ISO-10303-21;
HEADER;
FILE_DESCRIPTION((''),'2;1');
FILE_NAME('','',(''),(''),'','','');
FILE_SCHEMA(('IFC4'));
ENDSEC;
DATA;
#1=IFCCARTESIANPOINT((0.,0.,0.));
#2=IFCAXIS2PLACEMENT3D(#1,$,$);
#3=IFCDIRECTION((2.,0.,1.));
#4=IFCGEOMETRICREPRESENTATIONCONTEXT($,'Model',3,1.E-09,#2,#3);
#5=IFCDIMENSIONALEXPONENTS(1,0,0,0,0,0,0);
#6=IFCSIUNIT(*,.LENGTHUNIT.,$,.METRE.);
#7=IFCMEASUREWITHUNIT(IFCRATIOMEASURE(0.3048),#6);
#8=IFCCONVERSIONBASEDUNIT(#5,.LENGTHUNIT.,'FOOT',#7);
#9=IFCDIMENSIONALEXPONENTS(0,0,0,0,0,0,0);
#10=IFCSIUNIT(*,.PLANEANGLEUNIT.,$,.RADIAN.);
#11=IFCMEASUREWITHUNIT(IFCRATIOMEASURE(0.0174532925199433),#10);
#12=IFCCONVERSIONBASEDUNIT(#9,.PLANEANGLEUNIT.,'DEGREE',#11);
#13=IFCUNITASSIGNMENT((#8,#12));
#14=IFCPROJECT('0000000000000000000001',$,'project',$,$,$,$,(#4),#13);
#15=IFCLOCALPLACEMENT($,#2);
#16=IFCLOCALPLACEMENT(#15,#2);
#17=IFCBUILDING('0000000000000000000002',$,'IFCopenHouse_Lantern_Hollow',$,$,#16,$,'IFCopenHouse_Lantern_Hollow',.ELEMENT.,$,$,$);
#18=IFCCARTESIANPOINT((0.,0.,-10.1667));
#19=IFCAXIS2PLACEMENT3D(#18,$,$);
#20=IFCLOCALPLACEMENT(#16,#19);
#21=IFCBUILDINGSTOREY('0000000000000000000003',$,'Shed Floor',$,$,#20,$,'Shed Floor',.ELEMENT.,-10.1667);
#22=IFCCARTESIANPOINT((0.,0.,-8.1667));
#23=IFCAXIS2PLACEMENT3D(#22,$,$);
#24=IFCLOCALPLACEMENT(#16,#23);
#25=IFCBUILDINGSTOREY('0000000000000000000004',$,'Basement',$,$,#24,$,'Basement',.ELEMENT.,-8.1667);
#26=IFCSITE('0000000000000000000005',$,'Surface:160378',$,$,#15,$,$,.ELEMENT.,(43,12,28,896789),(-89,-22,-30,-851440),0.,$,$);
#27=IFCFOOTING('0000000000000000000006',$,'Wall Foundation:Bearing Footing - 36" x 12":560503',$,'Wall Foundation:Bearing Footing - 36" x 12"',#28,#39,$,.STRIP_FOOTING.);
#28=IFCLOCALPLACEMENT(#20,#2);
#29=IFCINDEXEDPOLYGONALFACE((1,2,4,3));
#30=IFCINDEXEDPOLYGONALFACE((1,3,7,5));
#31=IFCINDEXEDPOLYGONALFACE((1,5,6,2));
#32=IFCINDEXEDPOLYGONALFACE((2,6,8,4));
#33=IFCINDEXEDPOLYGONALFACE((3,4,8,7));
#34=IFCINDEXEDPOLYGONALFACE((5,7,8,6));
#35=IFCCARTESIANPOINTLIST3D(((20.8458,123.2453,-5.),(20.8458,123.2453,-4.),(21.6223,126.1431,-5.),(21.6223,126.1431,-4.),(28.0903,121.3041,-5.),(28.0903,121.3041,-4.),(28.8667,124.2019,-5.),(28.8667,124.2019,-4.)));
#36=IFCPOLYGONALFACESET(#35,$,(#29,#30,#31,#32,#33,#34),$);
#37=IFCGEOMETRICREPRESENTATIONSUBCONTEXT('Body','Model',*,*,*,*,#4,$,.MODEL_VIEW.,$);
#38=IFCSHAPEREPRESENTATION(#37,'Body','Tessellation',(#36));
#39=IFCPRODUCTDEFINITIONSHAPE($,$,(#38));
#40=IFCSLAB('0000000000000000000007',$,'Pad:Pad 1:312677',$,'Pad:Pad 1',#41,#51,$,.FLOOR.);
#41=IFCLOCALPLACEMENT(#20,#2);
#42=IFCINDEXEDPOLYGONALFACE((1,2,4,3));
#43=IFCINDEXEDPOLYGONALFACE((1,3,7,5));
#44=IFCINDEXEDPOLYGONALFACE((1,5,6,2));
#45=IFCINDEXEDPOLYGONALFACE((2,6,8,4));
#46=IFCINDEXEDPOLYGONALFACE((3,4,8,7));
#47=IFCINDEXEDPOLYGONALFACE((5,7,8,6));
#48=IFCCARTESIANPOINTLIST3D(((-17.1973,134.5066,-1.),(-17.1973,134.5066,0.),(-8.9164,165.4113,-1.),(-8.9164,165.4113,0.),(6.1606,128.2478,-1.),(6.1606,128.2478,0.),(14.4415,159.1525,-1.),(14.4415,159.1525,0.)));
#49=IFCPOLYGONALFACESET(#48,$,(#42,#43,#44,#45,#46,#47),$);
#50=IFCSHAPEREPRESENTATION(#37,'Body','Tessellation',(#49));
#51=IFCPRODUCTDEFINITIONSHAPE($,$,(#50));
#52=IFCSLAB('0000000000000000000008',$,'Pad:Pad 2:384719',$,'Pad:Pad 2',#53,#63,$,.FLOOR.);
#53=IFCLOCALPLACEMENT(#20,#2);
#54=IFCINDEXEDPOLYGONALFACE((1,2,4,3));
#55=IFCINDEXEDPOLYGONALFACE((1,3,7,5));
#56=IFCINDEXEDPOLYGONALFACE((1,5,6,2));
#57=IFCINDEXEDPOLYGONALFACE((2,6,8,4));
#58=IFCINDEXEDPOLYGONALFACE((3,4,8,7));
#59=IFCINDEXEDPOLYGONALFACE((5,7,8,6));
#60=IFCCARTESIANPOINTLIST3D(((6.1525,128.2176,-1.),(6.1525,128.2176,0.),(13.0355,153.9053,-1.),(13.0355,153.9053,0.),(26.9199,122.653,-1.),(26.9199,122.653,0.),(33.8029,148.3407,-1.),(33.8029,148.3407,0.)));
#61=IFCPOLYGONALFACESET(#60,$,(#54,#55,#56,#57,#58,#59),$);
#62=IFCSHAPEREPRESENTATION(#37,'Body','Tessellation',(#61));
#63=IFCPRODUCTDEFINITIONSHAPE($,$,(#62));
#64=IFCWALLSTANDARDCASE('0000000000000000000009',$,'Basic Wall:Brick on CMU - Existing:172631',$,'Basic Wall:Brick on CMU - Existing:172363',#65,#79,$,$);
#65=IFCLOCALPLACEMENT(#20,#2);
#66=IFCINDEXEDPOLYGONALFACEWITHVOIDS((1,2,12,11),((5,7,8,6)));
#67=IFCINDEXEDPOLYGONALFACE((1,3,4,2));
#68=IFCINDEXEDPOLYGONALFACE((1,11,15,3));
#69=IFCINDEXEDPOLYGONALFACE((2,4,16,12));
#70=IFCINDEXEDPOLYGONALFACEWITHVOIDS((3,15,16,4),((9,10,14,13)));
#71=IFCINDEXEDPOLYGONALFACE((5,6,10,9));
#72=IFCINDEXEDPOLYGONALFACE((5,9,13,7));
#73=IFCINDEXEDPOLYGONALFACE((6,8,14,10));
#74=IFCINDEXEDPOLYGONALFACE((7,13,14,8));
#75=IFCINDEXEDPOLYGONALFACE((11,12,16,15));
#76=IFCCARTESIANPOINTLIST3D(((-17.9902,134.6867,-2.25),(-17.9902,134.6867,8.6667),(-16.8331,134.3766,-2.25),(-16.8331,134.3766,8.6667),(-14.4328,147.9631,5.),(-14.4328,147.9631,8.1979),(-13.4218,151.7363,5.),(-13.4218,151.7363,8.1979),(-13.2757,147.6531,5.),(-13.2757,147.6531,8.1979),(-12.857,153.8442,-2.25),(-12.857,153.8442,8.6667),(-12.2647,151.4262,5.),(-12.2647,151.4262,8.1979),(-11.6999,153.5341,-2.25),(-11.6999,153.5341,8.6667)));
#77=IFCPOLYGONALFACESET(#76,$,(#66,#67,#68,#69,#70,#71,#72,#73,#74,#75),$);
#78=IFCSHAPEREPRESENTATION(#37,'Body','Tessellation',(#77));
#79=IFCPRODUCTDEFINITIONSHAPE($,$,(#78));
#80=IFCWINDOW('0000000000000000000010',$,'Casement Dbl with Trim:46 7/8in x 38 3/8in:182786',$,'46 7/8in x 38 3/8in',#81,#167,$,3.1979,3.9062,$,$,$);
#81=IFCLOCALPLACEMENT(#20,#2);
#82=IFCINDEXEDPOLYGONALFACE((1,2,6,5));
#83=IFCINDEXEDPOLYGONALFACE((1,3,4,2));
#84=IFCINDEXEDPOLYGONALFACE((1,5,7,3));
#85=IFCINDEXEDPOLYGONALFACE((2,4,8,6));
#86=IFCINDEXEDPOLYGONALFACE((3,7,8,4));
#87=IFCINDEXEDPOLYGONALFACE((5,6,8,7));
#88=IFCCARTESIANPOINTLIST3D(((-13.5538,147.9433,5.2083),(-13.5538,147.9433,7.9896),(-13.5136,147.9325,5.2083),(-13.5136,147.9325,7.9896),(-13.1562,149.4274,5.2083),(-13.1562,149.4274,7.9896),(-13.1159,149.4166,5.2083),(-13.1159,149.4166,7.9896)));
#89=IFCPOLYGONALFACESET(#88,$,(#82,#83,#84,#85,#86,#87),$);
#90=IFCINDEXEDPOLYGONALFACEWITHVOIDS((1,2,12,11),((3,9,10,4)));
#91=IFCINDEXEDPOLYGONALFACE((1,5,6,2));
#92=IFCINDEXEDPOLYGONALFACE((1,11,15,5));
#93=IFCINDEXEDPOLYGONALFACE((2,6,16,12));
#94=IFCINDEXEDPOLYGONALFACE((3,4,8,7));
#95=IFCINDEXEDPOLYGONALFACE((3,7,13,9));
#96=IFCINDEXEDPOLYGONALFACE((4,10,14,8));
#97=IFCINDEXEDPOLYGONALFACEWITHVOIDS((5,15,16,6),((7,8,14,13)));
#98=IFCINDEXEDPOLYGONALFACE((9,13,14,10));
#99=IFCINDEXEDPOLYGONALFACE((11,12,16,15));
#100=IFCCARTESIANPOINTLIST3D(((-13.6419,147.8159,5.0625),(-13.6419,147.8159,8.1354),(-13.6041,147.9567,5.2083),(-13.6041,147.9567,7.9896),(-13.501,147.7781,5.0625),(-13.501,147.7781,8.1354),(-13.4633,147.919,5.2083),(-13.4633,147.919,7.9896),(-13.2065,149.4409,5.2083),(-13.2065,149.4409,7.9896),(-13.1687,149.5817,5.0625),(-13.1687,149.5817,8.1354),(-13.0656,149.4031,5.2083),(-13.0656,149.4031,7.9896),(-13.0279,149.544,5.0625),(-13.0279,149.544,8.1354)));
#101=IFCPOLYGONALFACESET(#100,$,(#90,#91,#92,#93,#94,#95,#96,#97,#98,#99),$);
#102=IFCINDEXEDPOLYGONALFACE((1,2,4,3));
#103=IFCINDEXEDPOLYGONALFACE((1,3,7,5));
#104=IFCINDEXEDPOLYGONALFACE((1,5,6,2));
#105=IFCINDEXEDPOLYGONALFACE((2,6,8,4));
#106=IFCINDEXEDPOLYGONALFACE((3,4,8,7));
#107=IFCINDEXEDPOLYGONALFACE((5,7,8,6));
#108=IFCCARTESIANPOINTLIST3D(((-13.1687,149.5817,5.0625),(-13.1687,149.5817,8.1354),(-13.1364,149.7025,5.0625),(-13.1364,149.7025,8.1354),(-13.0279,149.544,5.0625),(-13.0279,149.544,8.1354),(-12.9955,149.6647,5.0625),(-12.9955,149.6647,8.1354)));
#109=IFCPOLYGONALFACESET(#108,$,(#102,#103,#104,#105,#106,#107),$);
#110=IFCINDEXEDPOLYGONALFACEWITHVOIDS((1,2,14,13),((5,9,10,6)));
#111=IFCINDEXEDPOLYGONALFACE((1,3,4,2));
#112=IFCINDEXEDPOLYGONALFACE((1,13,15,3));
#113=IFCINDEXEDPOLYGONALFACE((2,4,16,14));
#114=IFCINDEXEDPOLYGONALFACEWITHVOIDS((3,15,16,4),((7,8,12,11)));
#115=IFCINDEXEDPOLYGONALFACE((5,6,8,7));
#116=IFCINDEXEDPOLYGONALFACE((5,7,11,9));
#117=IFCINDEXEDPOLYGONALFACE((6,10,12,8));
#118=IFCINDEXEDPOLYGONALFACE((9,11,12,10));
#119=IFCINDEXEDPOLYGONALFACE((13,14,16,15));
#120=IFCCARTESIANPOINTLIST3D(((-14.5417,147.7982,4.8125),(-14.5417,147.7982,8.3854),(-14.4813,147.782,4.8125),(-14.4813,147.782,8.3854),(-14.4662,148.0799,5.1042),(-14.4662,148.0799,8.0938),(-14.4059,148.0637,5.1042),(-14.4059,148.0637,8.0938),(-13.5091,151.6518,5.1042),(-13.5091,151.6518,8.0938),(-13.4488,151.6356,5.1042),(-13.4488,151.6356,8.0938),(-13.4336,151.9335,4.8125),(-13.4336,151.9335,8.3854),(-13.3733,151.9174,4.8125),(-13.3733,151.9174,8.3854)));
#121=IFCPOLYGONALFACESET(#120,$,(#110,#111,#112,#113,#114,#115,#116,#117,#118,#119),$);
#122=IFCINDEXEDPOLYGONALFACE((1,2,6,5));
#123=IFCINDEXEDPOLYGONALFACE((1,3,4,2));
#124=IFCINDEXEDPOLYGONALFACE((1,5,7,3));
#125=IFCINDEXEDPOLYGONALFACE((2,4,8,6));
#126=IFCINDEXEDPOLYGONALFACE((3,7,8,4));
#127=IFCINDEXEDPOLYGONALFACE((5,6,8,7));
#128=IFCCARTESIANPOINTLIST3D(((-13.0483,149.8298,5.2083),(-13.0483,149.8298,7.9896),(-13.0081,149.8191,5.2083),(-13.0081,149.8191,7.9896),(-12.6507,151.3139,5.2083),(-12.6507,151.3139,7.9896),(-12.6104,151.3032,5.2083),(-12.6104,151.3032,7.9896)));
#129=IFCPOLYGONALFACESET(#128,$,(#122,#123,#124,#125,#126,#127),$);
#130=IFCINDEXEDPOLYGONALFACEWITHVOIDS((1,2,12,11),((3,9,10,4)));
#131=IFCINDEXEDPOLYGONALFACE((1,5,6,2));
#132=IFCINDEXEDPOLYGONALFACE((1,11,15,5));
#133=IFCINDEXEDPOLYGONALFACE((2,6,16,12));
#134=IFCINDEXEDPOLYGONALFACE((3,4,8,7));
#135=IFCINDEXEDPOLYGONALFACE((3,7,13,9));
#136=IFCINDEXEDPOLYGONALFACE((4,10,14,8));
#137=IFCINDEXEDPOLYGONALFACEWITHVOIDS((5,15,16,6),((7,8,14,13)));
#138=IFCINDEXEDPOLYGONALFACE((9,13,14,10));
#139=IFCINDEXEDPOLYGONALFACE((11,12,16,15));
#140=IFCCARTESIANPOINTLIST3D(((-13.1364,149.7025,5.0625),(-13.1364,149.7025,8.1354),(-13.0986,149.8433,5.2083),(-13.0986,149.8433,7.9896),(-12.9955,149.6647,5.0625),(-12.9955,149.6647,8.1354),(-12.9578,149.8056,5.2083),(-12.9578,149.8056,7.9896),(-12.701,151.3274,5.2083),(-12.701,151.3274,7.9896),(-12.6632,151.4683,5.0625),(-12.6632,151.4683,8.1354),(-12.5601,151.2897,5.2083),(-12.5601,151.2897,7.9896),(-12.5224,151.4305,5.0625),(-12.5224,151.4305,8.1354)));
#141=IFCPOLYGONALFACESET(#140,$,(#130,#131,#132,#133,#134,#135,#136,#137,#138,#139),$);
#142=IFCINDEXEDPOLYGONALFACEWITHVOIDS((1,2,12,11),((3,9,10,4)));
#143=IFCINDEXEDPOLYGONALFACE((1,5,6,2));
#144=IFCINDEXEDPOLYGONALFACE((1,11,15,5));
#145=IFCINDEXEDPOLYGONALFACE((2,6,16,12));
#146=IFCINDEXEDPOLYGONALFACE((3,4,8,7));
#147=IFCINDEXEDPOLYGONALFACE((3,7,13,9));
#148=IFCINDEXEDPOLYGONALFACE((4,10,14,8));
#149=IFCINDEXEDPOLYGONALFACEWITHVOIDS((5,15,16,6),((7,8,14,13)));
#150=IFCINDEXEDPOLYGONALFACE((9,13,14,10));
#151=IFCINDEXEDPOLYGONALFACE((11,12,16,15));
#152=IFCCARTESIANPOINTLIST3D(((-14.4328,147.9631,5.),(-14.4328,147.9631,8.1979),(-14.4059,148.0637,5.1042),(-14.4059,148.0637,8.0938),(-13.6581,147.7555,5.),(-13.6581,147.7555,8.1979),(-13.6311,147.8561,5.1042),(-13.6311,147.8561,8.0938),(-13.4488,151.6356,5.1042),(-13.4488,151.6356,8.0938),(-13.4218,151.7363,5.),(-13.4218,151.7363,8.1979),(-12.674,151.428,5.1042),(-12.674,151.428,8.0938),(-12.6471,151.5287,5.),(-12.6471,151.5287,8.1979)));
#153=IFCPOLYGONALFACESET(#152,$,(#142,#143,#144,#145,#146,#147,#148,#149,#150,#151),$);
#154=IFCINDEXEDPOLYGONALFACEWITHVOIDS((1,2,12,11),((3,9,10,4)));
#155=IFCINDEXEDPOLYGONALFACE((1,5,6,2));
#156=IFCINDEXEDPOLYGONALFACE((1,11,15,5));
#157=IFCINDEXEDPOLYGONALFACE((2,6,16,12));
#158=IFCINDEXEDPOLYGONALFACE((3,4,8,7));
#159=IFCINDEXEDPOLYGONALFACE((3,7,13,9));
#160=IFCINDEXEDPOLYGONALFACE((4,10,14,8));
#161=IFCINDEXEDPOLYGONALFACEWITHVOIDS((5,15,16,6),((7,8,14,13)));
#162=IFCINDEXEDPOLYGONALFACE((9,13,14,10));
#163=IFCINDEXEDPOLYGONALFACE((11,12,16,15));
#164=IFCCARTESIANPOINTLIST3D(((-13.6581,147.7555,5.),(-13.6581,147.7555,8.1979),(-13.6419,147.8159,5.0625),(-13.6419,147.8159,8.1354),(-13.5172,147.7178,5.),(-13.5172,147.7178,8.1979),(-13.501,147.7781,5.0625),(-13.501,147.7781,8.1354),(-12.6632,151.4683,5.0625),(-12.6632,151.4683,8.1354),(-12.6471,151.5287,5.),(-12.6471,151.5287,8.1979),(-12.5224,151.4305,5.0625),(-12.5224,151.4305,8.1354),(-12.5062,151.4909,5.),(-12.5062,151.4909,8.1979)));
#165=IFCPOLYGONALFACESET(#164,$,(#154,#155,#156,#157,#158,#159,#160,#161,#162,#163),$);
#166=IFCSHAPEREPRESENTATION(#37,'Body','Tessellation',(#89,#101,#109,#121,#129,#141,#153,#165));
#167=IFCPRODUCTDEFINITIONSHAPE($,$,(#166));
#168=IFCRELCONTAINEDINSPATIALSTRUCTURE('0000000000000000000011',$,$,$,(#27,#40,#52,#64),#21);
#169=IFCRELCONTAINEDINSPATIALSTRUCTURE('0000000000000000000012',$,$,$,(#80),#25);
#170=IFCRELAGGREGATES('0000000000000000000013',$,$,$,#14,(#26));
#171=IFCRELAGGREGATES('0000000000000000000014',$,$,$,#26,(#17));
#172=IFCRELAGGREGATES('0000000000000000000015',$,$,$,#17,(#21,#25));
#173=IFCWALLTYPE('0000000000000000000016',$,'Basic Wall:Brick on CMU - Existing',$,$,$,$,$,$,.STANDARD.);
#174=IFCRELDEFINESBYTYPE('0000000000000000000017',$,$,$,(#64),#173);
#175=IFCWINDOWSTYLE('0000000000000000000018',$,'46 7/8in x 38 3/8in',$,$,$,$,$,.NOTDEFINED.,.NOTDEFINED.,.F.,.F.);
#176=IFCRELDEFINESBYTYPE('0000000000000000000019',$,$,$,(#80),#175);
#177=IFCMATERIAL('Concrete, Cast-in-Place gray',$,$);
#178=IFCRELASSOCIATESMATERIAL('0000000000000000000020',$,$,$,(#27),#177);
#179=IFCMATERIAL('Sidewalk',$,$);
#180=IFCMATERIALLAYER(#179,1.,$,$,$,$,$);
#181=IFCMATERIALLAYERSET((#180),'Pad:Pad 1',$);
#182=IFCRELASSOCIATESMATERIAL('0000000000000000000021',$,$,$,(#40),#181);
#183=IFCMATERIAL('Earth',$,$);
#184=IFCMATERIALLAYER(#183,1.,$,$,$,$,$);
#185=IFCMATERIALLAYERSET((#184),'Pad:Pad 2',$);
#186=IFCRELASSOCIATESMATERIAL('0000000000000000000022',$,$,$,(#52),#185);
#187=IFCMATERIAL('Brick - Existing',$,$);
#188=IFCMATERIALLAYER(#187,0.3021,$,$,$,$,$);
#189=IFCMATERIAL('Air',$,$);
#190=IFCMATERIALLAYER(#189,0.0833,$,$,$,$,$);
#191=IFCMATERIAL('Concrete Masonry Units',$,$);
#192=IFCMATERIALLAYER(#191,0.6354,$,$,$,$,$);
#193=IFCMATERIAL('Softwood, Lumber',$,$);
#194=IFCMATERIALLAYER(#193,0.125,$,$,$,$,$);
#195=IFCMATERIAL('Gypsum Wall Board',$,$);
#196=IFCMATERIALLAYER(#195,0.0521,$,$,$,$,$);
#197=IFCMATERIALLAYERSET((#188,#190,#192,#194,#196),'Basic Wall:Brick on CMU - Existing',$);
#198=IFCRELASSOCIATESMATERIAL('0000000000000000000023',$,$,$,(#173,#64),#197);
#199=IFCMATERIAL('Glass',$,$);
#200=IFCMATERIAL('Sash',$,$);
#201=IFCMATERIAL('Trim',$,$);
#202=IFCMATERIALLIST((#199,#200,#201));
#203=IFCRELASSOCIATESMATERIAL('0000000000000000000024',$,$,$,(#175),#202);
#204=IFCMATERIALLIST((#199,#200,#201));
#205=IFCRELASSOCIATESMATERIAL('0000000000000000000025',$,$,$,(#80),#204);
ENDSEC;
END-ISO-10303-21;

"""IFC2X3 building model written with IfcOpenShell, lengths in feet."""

from ifc_helpers import new_model, entity, si_unit, converted_unit, direction, frame, frame_2d, origin, place, context, subcontext, project, spatial, polyline, rectangle, outline, extrude, source, transform, mapped, material, material_list, layer, layer_set, layer_usage, type_object, type_shapes, element, fill, save


model = new_model("IFC2X3")

# Units and contexts
model_context = context("Model", 3, precision=1e-09, world=origin(), true_north=direction((2.0, 0.0, 1.0)))
body_context = subcontext(model_context, "Body", "Model", "MODEL_VIEW")
ifc_project = project(units=[converted_unit("LENGTHUNIT", "FOOT", entity("IfcRatioMeasure", 0.3048), si_unit("LENGTHUNIT", "METRE"), dimensions=[1, 0, 0, 0, 0, 0, 0]), converted_unit("PLANEANGLEUNIT", "DEGREE", entity("IfcRatioMeasure", 0.0174532925199433), si_unit("PLANEANGLEUNIT", "RADIAN"), dimensions=[0, 0, 0, 0, 0, 0, 0])], contexts=[model_context])

# Site, building, storey
site_placement = place(None, origin())
site = spatial("IfcSite", under=ifc_project, at=site_placement, Name="Surface:160378", CompositionType="ELEMENT", RefLatitude=(43, 12, 28, 896789), RefLongitude=(-89, -22, -30, -851440), RefElevation=0.0)
building_placement = place(site_placement, origin())
building = spatial("IfcBuilding", under=site, at=building_placement, Name="IFCopenHouse_Lantern_Hollow", LongName="IFCopenHouse_Lantern_Hollow", CompositionType="ELEMENT")
storey_1_placement = place(building_placement, frame((0.0, 0.0, -10.1667)))
storey_1 = spatial("IfcBuildingStorey", under=building, at=storey_1_placement, Name="Shed Floor", LongName="Shed Floor", CompositionType="ELEMENT", Elevation=-10.1667)

# Footing
ifc_material_1 = material(Name="Concrete, Cast-in-Place gray")
footing_placement = place(storey_1_placement, origin())
element("IfcFooting", 1, at=footing_placement, inside=storey_1, material=ifc_material_1, Name="Wall Foundation:Bearing Footing - 36\" x 12\":560503", ObjectType="Wall Foundation:Bearing Footing - 36\" x 12\"", PredefinedType="STRIP_FOOTING", context=body_context, shape_type="SweptSolid", body=[
    extrude(rectangle(XDim=7.5, YDim=3.0, at=frame_2d((0.0, 0.0), x_axis=(1.0, 0.0))), frame((24.8563, 123.7236, -5.0), z_axis=(0.0, 0.0, 1.0), x_axis=(0.965926, -0.258819, 0.0)), (0.0, 0.0, 1.0), 1.0),
])

# Slabs
ifc_material_2 = material(Name="Sidewalk")
ifc_layer_1 = layer(ifc_material_2, 1.0)
ifc_layer_set_1 = layer_set([ifc_layer_1], Name="Pad:Pad 1")
ifc_layer_usage_1 = layer_usage(ifc_layer_set_1, "AXIS3", "NEGATIVE", 0.0)
slab_1_placement = place(storey_1_placement, frame((-17.1973, 128.2478, -1.0)))
element("IfcSlab", 2, at=slab_1_placement, inside=storey_1, material=ifc_layer_usage_1, Name="Pad:Pad 1:312677", ObjectType="Pad:Pad 1", PredefinedType="FLOOR", context=body_context, shape_type="SweptSolid", body=[
    extrude(rectangle(XDim=24.1819, YDim=31.9949, at=frame_2d((0.0, 0.0), x_axis=(0.965926, 0.258819))), frame((15.8194, 18.5817, 1.0), z_axis=(0.0, 0.0, -1.0), x_axis=(-1.0, 0.0, 0.0)), (0.0, 0.0, 1.0), 1.0),
])
ifc_material_3 = material(Name="Earth")
ifc_layer_2 = layer(ifc_material_3, 1.0)
ifc_layer_set_2 = layer_set([ifc_layer_2], Name="Pad:Pad 2")
ifc_layer_usage_2 = layer_usage(ifc_layer_set_2, "AXIS3", "NEGATIVE", 0.0)
slab_2_placement = place(storey_1_placement, frame((6.1525, 122.653, -1.0)))
element("IfcSlab", 3, at=slab_2_placement, inside=storey_1, material=ifc_layer_usage_2, Name="Pad:Pad 2:384719", ObjectType="Pad:Pad 2", PredefinedType="FLOOR", context=body_context, shape_type="SweptSolid", body=[
    extrude(rectangle(XDim=26.5938, YDim=21.5, at=frame_2d((0.0, 0.0), x_axis=(0.258819, -0.965926))), frame((13.8252, 15.6261, 1.0), z_axis=(0.0, 0.0, -1.0), x_axis=(-1.0, 0.0, 0.0)), (0.0, 0.0, 1.0), 1.0),
])

# Shared definitions
ifc_material_4 = material(Name="Brick - Existing")
ifc_layer_3 = layer(ifc_material_4, 0.3021)
ifc_material_5 = material(Name="Air")
ifc_layer_4 = layer(ifc_material_5, 0.0833)
ifc_material_6 = material(Name="Concrete Masonry Units")
ifc_layer_5 = layer(ifc_material_6, 0.6354)
ifc_material_7 = material(Name="Softwood, Lumber")
ifc_layer_6 = layer(ifc_material_7, 0.125)
ifc_material_8 = material(Name="Gypsum Wall Board")
ifc_layer_7 = layer(ifc_material_8, 0.0521)
ifc_layer_set_3 = layer_set([ifc_layer_3, ifc_layer_4, ifc_layer_5, ifc_layer_6, ifc_layer_7], Name="Basic Wall:Brick on CMU - Existing")
wall_type_1 = type_object("IfcWallType", Name="Basic Wall:Brick on CMU - Existing", PredefinedType="STANDARD", material=ifc_layer_set_3)

# Shared definitions
storey_2_placement = place(building_placement, frame((0.0, 0.0, -8.1667)))
storey_2 = spatial("IfcBuildingStorey", under=building, at=storey_2_placement, Name="Basement", LongName="Basement", CompositionType="ELEMENT", Elevation=-8.1667)

# Shared definitions
ifc_material_9 = material(Name="Glass")
ifc_material_10 = material(Name="Sash")
ifc_material_11 = material(Name="Trim")

# Wall, opening, window
ifc_layer_usage_3 = layer_usage(ifc_layer_set_3, "AXIS2", "NEGATIVE", 0.599)
wall_1_placement = place(storey_1_placement, frame((-12.2784, 153.6892, -2.25), z_axis=(0.0, 0.0, 1.0), x_axis=(-0.258819, -0.965926, 0.0)))
wall_1 = element("IfcWallStandardCase", 4, at=wall_1_placement, inside=storey_1, type_object=wall_type_1, material=ifc_layer_usage_3, Name="Basic Wall:Brick on CMU - Existing:172631", ObjectType="Basic Wall:Brick on CMU - Existing:172363", context=body_context, shape_type="SweptSolid", body=[
    extrude(rectangle(XDim=19.8333, YDim=1.1979, at=frame_2d((9.9167, 0.0), x_axis=(-1.0, 0.0))), origin(), (0.0, 0.0, 1.0), 10.9167),
])
opening_1_placement = place(wall_1_placement, frame((2.1823, -0.599, 7.25)))
opening_1 = element("IfcOpeningElement", 5, at=opening_1_placement, cuts=wall_1, ObjectType="Opening", context=body_context, shape_type="SweptSolid", body=[
    extrude(rectangle(XDim=3.1979, YDim=3.9062, at=frame_2d((1.599, 1.9531), x_axis=(-1.0, 0.0))), frame((0.0, 0.0, 0.0), z_axis=(0.0, 1.0, 0.0), x_axis=(0.0, 0.0, 1.0)), (0.0, 0.0, 1.0), 1.1979),
])
ifc_material_list_1 = material_list([ifc_material_9, ifc_material_10, ifc_material_11])
ifc_material_list_2 = material_list([ifc_material_9, ifc_material_10, ifc_material_11])
window_style_1 = type_object("IfcWindowStyle", Name="46 7/8in x 38 3/8in", ConstructionType="NOTDEFINED", OperationType="NOTDEFINED", ParameterTakesPrecedence=False, Sizeable=False, material=ifc_material_list_2)
shared_shape_1 = source(origin(), body_context, "Body", "SweptSolid", [
    extrude(rectangle(XDim=0.0417, YDim=1.5365, at=frame_2d((0.0, 0.0), x_axis=(1.0, 0.0))), frame((2.9297, 0.875, 0.2083), z_axis=(0.0, 0.0, 1.0), x_axis=(0.0, -1.0, 0.0)), (0.0, 0.0, 1.0), 2.7813),
    extrude(outline(polyline([(-0.9141, -1.5365), (0.9141, -1.5365), (0.9141, 1.5365), (-0.9141, 1.5365), (-0.9141, -1.5365)]), holes=[polyline([(-0.7682, -1.3906), (-0.7682, 1.3906), (0.7682, 1.3906), (0.7682, -1.3906), (-0.7682, -1.3906)])]), frame((2.9297, 0.8021, 1.599), z_axis=(0.0, 1.0, 0.0), x_axis=(1.0, 0.0, 0.0)), (0.0, 0.0, 1.0), 0.1458),
    extrude(rectangle(XDim=0.1458, YDim=0.125, at=frame_2d((0.0, 0.0), x_axis=(1.0, 0.0))), frame((1.9531, 0.875, 0.0625), z_axis=(0.0, 0.0, 1.0), x_axis=(0.0, 1.0, 0.0)), (0.0, 0.0, 1.0), 3.0729),
    extrude(outline(polyline([(-1.7865, -2.1406), (1.7865, -2.1406), (1.7865, 2.1406), (-1.7865, 2.1406), (-1.7865, -2.1406)]), holes=[polyline([(-1.4948, -1.849), (-1.4948, 1.849), (1.4948, 1.849), (1.4948, -1.849), (-1.4948, -1.849)])]), frame((1.9531, -0.0625, 1.599), z_axis=(0.0, 1.0, 0.0), x_axis=(0.0, 0.0, -1.0)), (0.0, 0.0, 1.0), 0.0625),
    extrude(rectangle(XDim=0.0417, YDim=1.5365, at=frame_2d((0.0, 0.0), x_axis=(1.0, 0.0))), frame((0.9766, 0.875, 0.2083), z_axis=(0.0, 0.0, 1.0), x_axis=(0.0, 1.0, 0.0)), (0.0, 0.0, 1.0), 2.7813),
    extrude(outline(polyline([(-0.9141, -1.5365), (0.9141, -1.5365), (0.9141, 1.5365), (-0.9141, 1.5365), (-0.9141, -1.5365)]), holes=[polyline([(-0.7682, -1.3906), (-0.7682, 1.3906), (0.7682, 1.3906), (0.7682, -1.3906), (-0.7682, -1.3906)])]), frame((0.9766, 0.8021, 1.599), z_axis=(0.0, 1.0, 0.0), x_axis=(1.0, 0.0, 0.0)), (0.0, 0.0, 1.0), 0.1458),
    extrude(outline(polyline([(-1.9531, -1.599), (1.9531, -1.599), (1.9531, 1.599), (-1.9531, 1.599), (-1.9531, -1.599)]), holes=[polyline([(-1.849, -1.4948), (-1.849, 1.4948), (1.849, 1.4948), (1.849, -1.4948), (-1.849, -1.4948)])]), frame((1.9531, 0.0, 1.599), z_axis=(0.0, 1.0, 0.0), x_axis=(1.0, 0.0, 0.0)), (0.0, 0.0, 1.0), 0.8021),
    extrude(outline(polyline([(-1.599, -1.9531), (1.599, -1.9531), (1.599, 1.9531), (-1.599, 1.9531), (-1.599, -1.9531)]), holes=[polyline([(-1.5365, -1.8906), (-1.5365, 1.8906), (1.5365, 1.8906), (1.5365, -1.8906), (-1.5365, -1.8906)])]), frame((1.9531, 0.8021, 1.599), z_axis=(0.0, 1.0, 0.0), x_axis=(0.0, 0.0, -1.0)), (0.0, 0.0, 1.0), 0.1458),
])
type_shapes(window_style_1, [shared_shape_1])
window_1_placement = place(opening_1_placement, origin())
window_1 = element("IfcWindow", 6, at=window_1_placement, inside=storey_2, type_object=window_style_1, material=ifc_material_list_1, Name="Casement Dbl with Trim:46 7/8in x 38 3/8in:182786", ObjectType="46 7/8in x 38 3/8in", OverallHeight=3.1979, OverallWidth=3.9062, context=body_context, shape_type="MappedRepresentation", body=[
    mapped(shared_shape_1, transform((0.0, 0.0, 0.0), scale=1.0)),
])
fill(opening_1, window_1)

save(model, "model.ifc")
